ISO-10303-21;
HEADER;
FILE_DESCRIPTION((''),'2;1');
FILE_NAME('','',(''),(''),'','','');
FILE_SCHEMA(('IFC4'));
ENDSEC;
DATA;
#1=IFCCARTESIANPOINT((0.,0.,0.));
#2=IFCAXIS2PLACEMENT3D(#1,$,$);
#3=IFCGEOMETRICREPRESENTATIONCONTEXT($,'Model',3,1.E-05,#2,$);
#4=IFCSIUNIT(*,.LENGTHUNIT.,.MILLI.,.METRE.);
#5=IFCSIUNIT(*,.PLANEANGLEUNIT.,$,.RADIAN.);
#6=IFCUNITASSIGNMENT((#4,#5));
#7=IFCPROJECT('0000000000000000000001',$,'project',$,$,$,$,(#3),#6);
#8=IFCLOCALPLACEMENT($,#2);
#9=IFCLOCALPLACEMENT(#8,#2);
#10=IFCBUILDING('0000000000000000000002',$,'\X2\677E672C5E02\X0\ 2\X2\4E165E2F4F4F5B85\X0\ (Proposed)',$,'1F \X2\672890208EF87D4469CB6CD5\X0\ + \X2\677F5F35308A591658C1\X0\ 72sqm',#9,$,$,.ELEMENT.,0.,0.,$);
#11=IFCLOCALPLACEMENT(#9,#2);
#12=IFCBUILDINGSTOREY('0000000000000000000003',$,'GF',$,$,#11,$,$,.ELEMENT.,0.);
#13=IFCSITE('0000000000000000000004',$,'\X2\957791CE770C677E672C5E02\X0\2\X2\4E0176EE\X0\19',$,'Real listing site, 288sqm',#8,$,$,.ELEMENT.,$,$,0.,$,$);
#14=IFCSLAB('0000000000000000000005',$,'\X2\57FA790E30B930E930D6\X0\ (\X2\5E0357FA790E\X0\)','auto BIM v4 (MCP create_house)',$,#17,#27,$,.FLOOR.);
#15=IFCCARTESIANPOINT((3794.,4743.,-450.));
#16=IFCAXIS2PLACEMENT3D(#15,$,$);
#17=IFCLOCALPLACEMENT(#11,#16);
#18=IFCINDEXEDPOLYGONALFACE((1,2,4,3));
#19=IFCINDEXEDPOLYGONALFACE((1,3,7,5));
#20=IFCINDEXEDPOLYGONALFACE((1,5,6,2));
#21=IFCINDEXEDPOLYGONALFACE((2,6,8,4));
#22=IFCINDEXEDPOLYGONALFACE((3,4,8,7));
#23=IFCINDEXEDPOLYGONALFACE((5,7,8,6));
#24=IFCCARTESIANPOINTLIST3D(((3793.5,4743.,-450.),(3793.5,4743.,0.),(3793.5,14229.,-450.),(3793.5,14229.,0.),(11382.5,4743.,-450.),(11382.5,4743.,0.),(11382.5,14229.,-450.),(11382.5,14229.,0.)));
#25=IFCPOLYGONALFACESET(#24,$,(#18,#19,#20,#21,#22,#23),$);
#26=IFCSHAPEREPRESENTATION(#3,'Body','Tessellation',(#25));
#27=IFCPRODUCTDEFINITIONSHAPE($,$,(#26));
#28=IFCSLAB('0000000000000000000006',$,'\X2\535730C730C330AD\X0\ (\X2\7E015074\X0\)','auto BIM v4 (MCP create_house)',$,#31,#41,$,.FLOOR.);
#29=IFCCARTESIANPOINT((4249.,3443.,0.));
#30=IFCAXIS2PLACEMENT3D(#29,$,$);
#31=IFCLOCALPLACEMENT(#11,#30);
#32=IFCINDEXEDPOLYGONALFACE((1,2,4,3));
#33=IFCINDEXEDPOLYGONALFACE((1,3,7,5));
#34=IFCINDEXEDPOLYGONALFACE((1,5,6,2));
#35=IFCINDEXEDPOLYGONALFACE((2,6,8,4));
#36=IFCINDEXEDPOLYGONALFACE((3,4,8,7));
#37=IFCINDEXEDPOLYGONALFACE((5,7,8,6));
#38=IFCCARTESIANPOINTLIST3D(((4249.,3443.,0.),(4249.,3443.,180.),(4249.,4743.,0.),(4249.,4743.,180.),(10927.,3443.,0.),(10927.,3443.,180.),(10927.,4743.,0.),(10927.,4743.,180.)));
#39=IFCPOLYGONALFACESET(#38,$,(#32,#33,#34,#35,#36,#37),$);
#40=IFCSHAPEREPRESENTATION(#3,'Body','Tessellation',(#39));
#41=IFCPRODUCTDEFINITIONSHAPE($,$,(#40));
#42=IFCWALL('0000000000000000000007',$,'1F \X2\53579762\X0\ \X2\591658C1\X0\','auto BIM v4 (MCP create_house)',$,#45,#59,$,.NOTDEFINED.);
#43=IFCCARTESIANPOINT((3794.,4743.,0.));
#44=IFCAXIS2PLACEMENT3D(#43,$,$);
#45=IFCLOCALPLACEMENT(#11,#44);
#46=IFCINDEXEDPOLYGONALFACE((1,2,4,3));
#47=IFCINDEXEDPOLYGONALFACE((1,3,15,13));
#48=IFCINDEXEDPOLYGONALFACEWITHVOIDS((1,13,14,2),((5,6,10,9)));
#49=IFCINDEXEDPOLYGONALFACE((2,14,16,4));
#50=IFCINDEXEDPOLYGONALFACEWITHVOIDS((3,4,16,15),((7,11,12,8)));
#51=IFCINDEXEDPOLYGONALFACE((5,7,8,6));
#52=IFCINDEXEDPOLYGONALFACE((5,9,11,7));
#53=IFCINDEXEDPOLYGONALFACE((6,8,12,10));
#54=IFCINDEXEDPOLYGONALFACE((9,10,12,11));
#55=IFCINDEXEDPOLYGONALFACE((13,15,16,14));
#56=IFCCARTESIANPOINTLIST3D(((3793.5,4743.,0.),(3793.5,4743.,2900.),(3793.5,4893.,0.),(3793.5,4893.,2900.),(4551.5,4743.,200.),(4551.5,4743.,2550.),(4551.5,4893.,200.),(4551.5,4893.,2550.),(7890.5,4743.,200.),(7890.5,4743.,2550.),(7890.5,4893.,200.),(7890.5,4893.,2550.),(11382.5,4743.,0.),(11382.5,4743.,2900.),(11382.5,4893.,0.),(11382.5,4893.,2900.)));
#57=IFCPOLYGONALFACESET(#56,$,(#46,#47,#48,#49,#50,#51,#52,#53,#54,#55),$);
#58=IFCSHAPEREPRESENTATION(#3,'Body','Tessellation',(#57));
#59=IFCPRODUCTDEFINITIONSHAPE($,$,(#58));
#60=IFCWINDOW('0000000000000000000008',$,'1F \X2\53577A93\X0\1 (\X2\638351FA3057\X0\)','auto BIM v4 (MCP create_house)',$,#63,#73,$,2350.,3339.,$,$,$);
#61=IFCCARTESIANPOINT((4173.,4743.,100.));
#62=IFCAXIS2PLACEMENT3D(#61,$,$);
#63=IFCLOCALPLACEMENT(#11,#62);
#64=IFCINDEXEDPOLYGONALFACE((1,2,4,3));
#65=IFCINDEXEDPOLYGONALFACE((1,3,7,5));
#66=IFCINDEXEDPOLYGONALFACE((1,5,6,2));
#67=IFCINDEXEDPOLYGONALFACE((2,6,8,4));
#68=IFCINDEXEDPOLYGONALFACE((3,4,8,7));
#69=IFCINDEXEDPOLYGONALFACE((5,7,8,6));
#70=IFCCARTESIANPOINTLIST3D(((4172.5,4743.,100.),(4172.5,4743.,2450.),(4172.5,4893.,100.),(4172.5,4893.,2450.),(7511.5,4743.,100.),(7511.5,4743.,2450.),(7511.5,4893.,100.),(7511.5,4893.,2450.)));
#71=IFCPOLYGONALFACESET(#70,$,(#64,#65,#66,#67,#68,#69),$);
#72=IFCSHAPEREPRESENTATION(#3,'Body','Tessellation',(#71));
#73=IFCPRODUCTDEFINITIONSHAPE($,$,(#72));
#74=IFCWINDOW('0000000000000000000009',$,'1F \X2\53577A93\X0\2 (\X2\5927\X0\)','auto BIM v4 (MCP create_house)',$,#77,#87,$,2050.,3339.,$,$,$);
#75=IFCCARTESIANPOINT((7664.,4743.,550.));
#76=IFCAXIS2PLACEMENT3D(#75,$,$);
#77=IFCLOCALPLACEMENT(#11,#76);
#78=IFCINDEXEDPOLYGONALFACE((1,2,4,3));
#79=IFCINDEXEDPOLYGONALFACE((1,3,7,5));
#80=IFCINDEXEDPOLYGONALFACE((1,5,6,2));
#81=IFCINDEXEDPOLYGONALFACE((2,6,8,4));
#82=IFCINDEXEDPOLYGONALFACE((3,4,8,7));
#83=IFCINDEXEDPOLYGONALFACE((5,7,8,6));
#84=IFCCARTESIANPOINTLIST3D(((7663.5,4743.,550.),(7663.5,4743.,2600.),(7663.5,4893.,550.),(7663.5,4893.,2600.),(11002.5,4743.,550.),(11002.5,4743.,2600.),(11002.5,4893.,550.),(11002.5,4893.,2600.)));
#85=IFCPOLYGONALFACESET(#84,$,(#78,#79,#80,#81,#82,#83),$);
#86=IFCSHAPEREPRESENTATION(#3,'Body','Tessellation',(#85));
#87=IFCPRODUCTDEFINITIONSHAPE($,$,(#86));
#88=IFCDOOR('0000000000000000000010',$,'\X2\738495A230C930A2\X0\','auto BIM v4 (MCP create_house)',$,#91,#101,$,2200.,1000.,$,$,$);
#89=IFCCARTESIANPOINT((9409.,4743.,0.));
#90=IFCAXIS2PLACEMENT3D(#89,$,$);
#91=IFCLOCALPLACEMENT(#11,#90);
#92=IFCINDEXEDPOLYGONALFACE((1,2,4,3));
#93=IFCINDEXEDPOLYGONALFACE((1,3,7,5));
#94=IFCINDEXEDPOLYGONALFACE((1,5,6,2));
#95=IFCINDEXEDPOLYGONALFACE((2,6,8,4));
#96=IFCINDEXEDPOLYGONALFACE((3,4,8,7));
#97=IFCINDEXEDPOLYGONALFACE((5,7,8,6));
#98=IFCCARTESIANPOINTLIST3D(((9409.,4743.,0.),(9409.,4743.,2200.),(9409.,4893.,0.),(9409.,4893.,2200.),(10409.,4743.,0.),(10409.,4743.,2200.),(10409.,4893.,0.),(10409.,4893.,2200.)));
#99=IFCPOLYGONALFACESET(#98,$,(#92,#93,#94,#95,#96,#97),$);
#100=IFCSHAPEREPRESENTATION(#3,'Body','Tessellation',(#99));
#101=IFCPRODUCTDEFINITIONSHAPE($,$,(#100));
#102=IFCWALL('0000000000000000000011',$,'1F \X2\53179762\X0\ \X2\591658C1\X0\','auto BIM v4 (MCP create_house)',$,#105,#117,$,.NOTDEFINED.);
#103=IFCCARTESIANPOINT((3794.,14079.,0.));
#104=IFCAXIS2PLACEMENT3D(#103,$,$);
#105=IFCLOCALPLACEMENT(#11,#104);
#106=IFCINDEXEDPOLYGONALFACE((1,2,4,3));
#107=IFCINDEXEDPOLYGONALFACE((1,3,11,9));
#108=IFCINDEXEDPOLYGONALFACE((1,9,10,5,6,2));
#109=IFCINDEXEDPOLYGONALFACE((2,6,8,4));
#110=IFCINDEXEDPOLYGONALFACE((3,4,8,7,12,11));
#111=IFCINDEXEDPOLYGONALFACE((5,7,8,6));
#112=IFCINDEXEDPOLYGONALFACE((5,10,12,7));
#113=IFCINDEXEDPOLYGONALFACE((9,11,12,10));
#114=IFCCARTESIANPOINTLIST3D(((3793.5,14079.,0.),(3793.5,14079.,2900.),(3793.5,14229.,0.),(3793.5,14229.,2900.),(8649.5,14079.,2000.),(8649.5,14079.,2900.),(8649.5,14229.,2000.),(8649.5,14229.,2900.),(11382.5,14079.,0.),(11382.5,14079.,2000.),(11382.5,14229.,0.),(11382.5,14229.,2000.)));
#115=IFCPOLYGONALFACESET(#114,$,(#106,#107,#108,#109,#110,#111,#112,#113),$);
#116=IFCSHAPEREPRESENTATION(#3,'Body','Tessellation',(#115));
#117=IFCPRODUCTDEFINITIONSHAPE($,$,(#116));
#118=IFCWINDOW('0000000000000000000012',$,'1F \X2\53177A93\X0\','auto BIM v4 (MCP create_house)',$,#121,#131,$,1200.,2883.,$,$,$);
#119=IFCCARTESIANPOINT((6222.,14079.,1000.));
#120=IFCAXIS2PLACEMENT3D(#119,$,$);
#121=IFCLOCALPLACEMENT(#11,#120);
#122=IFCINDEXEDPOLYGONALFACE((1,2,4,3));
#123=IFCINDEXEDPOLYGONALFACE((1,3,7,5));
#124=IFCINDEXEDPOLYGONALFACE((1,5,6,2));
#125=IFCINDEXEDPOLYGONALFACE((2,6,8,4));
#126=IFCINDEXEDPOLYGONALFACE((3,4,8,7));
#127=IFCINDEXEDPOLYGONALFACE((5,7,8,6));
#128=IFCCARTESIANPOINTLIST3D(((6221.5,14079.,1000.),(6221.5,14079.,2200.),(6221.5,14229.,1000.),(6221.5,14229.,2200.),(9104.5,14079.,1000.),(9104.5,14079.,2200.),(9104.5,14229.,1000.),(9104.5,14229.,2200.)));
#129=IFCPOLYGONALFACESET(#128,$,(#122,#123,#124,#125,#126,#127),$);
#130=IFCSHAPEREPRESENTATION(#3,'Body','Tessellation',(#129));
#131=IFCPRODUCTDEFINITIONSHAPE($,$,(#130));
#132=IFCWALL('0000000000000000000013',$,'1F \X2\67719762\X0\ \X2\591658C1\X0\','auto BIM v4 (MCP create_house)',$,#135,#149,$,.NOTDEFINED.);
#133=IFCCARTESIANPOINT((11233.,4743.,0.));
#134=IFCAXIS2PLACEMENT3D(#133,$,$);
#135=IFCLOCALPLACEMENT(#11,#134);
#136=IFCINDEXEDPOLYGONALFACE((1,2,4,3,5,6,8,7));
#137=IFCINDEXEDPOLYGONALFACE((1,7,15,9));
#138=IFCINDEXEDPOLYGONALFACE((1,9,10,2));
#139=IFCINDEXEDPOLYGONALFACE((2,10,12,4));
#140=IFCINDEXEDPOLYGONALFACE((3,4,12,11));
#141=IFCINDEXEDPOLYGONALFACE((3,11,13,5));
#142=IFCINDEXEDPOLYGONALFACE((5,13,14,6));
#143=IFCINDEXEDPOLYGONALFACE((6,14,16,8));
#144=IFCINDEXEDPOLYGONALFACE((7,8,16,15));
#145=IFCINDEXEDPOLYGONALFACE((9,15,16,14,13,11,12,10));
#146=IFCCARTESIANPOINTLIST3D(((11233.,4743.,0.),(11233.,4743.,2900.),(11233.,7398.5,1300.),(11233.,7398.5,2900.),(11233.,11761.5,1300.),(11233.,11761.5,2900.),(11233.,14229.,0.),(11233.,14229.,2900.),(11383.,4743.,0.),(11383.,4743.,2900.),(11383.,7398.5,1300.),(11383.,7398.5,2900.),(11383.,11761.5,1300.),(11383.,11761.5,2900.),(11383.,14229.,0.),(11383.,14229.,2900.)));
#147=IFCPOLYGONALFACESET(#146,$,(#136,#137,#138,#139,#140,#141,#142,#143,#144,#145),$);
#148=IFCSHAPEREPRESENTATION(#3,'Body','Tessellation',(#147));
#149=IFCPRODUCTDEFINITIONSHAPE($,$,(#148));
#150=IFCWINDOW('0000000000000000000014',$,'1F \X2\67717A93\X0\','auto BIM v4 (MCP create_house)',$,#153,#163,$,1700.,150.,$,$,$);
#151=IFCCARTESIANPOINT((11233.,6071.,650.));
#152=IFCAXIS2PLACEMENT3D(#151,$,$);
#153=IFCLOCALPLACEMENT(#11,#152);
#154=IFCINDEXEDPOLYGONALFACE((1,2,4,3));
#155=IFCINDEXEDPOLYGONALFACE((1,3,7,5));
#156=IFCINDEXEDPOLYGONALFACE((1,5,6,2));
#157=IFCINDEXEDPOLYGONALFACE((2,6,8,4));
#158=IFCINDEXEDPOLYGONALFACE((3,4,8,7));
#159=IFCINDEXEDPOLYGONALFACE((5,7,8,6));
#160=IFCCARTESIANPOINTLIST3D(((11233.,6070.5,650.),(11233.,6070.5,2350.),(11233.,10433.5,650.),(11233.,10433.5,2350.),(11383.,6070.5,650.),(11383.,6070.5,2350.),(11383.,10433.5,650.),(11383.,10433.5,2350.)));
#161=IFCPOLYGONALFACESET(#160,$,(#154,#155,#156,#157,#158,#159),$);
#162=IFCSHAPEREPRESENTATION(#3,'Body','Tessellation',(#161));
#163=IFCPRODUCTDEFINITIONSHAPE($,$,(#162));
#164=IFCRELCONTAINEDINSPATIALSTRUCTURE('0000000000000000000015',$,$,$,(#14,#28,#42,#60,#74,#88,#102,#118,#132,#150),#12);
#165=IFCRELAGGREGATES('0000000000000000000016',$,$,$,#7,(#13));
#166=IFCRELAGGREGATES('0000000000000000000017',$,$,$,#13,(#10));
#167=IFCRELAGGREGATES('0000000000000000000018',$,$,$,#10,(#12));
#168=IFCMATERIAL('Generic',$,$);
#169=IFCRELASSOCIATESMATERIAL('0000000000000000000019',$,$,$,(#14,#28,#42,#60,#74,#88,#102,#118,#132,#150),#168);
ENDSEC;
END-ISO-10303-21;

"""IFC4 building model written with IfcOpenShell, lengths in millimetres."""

from ifc_helpers import new_model, si_unit, frame, frame_2d, origin, place, context, project, spatial, rectangle, extrude, material, element, fill, save


model = new_model("IFC4")

# Units and contexts
model_context = context("Model", 3, precision=1e-05, world=origin())
ifc_project = project(units=[si_unit("LENGTHUNIT", "METRE", prefix="MILLI"), si_unit("PLANEANGLEUNIT", "RADIAN")], contexts=[model_context])

# Site, building, storey
site_placement = place(None, origin())
site = spatial("IfcSite", under=ifc_project, at=site_placement, Name="長野県松本市2丁目19", ObjectType="Real listing site, 288sqm", CompositionType="ELEMENT", RefElevation=0.0)
building_placement = place(site_placement, origin())
building = spatial("IfcBuilding", under=site, at=building_placement, Name="松本市 2世帯住宅 (Proposed)", ObjectType="1F 木造軸組構法 + 板張り外壁 72sqm", CompositionType="ELEMENT", ElevationOfRefHeight=0.0, ElevationOfTerrain=0.0)
storey_placement = place(building_placement, origin())
storey = spatial("IfcBuildingStorey", under=building, at=storey_placement, Name="GF", CompositionType="ELEMENT", Elevation=0.0)

# Slabs
ifc_material = material(Name="Generic")
slab_1_placement = place(storey_placement, frame((3794.0, 4743.0, -450.0)))
element("IfcSlab", 1, at=slab_1_placement, inside=storey, material=ifc_material, Name="基礎スラブ (布基礎)", Description="auto BIM v4 (MCP create_house)", PredefinedType="FLOOR", context=model_context, shape_type="SweptSolid", body=[
    extrude(rectangle(XDim=7589.0, YDim=9486.0, at=frame_2d((3794.0, 4743.0))), frame((3794.0, 4743.0, -450.0)), (0.0, 0.0, 1.0), 450.0),
])
slab_2_placement = place(storey_placement, frame((4249.0, 3443.0, 0.0)))
element("IfcSlab", 2, at=slab_2_placement, inside=storey, material=ifc_material, Name="南デッキ (縁側)", Description="auto BIM v4 (MCP create_house)", PredefinedType="FLOOR", context=model_context, shape_type="SweptSolid", body=[
    extrude(rectangle(XDim=6678.0, YDim=1300.0, at=frame_2d((3339.0, 650.0))), frame((4249.0, 3443.0, 0.0)), (0.0, 0.0, 1.0), 180.0),
])

# Wall, openings, windows, door
wall_1_placement = place(storey_placement, frame((3794.0, 4743.0, 0.0)))
wall_1 = element("IfcWall", 3, at=wall_1_placement, inside=storey, material=ifc_material, Name="1F 南面 外壁", Description="auto BIM v4 (MCP create_house)", PredefinedType="NOTDEFINED", context=model_context, shape_type="SweptSolid", body=[
    extrude(rectangle(XDim=7589.0, YDim=150.0, at=frame_2d((3794.0, 75.0))), frame((3794.0, 4743.0, 0.0)), (0.0, 0.0, 1.0), 2900.0),
])
opening_1_placement = place(storey_placement, frame((4173.0, 4743.0, 100.0)))
opening_1 = element("IfcOpeningElement", 4, at=opening_1_placement, cuts=wall_1, PredefinedType="NOTDEFINED", context=model_context, shape_type="SweptSolid", body=[
    extrude(rectangle(XDim=3339.0, YDim=150.0, at=frame_2d((1669.0, 75.0))), frame((4173.0, 4743.0, 100.0)), (0.0, 0.0, 1.0), 2350.0),
])
opening_2_placement = place(storey_placement, frame((7664.0, 4743.0, 550.0)))
opening_2 = element("IfcOpeningElement", 5, at=opening_2_placement, cuts=wall_1, PredefinedType="NOTDEFINED", context=model_context, shape_type="SweptSolid", body=[
    extrude(rectangle(XDim=3339.0, YDim=150.0, at=frame_2d((1669.0, 75.0))), frame((7664.0, 4743.0, 550.0)), (0.0, 0.0, 1.0), 2050.0),
])
opening_3_placement = place(storey_placement, frame((9409.0, 4743.0, 0.0)))
opening_3 = element("IfcOpeningElement", 6, at=opening_3_placement, cuts=wall_1, PredefinedType="NOTDEFINED", context=model_context, shape_type="SweptSolid", body=[
    extrude(rectangle(XDim=1000.0, YDim=150.0, at=frame_2d((500.0, 75.0))), frame((9409.0, 4743.0, 0.0)), (0.0, 0.0, 1.0), 2200.0),
])
window_1_placement = place(storey_placement, frame((4173.0, 4743.0, 100.0)))
window_1 = element("IfcWindow", 7, at=window_1_placement, inside=storey, material=ifc_material, Name="1F 南窓1 (掃出し)", Description="auto BIM v4 (MCP create_house)", OverallHeight=2350.0, OverallWidth=3339.0, context=model_context, shape_type="SweptSolid", body=[
    extrude(rectangle(XDim=3339.0, YDim=150.0, at=frame_2d((1669.0, 75.0))), frame((4173.0, 4743.0, 100.0)), (0.0, 0.0, 1.0), 2350.0),
])
fill(opening_1, window_1)
window_2_placement = place(storey_placement, frame((7664.0, 4743.0, 550.0)))
window_2 = element("IfcWindow", 8, at=window_2_placement, inside=storey, material=ifc_material, Name="1F 南窓2 (大)", Description="auto BIM v4 (MCP create_house)", OverallHeight=2050.0, OverallWidth=3339.0, context=model_context, shape_type="SweptSolid", body=[
    extrude(rectangle(XDim=3339.0, YDim=150.0, at=frame_2d((1669.0, 75.0))), frame((7664.0, 4743.0, 550.0)), (0.0, 0.0, 1.0), 2050.0),
])
fill(opening_2, window_2)
door_placement = place(storey_placement, frame((9409.0, 4743.0, 0.0)))
door = element("IfcDoor", 9, at=door_placement, inside=storey, material=ifc_material, Name="玄関ドア", Description="auto BIM v4 (MCP create_house)", OverallHeight=2200.0, OverallWidth=1000.0, context=model_context, shape_type="SweptSolid", body=[
    extrude(rectangle(XDim=1000.0, YDim=150.0, at=frame_2d((500.0, 75.0))), frame((9409.0, 4743.0, 0.0)), (0.0, 0.0, 1.0), 2200.0),
])
fill(opening_3, door)

# Walls, openings, windows
wall_2_placement = place(storey_placement, frame((3794.0, 14079.0, 0.0)))
wall_2 = element("IfcWall", 10, at=wall_2_placement, inside=storey, material=ifc_material, Name="1F 北面 外壁", Description="auto BIM v4 (MCP create_house)", PredefinedType="NOTDEFINED", context=model_context, shape_type="SweptSolid", body=[
    extrude(rectangle(XDim=7589.0, YDim=150.0, at=frame_2d((3794.0, 75.0))), frame((3794.0, 14079.0, 0.0)), (0.0, 0.0, 1.0), 2900.0),
])
opening_4_placement = place(storey_placement, frame((6222.0, 14079.0, 1000.0)))
opening_4 = element("IfcOpeningElement", 11, at=opening_4_placement, cuts=wall_2, PredefinedType="NOTDEFINED", context=model_context, shape_type="SweptSolid", body=[
    extrude(rectangle(XDim=2883.0, YDim=150.0, at=frame_2d((1441.0, 75.0))), frame((6222.0, 14079.0, 1000.0)), (0.0, 0.0, 1.0), 1200.0),
])
window_3_placement = place(storey_placement, frame((6222.0, 14079.0, 1000.0)))
window_3 = element("IfcWindow", 12, at=window_3_placement, inside=storey, material=ifc_material, Name="1F 北窓", Description="auto BIM v4 (MCP create_house)", OverallHeight=1200.0, OverallWidth=2883.0, context=model_context, shape_type="SweptSolid", body=[
    extrude(rectangle(XDim=2883.0, YDim=150.0, at=frame_2d((1441.0, 75.0))), frame((6222.0, 14079.0, 1000.0)), (0.0, 0.0, 1.0), 1200.0),
])
fill(opening_4, window_3)
wall_3_placement = place(storey_placement, frame((11233.0, 4743.0, 0.0)))
wall_3 = element("IfcWall", 13, at=wall_3_placement, inside=storey, material=ifc_material, Name="1F 東面 外壁", Description="auto BIM v4 (MCP create_house)", PredefinedType="NOTDEFINED", context=model_context, shape_type="SweptSolid", body=[
    extrude(rectangle(XDim=150.0, YDim=9486.0, at=frame_2d((75.0, 4743.0))), frame((11233.0, 4743.0, 0.0)), (0.0, 0.0, 1.0), 2900.0),
])
opening_5_placement = place(storey_placement, frame((11233.0, 6071.0, 650.0)))
opening_5 = element("IfcOpeningElement", 14, at=opening_5_placement, cuts=wall_3, PredefinedType="NOTDEFINED", context=model_context, shape_type="SweptSolid", body=[
    extrude(rectangle(XDim=150.0, YDim=4363.0, at=frame_2d((75.0, 2181.0))), frame((11233.0, 6071.0, 650.0)), (0.0, 0.0, 1.0), 1700.0),
])
window_4_placement = place(storey_placement, frame((11233.0, 6071.0, 650.0)))
window_4 = element("IfcWindow", 15, at=window_4_placement, inside=storey, material=ifc_material, Name="1F 東窓", Description="auto BIM v4 (MCP create_house)", OverallHeight=1700.0, OverallWidth=150.0, context=model_context, shape_type="SweptSolid", body=[
    extrude(rectangle(XDim=150.0, YDim=4363.0, at=frame_2d((75.0, 2181.0))), frame((11233.0, 6071.0, 650.0)), (0.0, 0.0, 1.0), 1700.0),
])
fill(opening_5, window_4)

save(model, "model.ifc")
